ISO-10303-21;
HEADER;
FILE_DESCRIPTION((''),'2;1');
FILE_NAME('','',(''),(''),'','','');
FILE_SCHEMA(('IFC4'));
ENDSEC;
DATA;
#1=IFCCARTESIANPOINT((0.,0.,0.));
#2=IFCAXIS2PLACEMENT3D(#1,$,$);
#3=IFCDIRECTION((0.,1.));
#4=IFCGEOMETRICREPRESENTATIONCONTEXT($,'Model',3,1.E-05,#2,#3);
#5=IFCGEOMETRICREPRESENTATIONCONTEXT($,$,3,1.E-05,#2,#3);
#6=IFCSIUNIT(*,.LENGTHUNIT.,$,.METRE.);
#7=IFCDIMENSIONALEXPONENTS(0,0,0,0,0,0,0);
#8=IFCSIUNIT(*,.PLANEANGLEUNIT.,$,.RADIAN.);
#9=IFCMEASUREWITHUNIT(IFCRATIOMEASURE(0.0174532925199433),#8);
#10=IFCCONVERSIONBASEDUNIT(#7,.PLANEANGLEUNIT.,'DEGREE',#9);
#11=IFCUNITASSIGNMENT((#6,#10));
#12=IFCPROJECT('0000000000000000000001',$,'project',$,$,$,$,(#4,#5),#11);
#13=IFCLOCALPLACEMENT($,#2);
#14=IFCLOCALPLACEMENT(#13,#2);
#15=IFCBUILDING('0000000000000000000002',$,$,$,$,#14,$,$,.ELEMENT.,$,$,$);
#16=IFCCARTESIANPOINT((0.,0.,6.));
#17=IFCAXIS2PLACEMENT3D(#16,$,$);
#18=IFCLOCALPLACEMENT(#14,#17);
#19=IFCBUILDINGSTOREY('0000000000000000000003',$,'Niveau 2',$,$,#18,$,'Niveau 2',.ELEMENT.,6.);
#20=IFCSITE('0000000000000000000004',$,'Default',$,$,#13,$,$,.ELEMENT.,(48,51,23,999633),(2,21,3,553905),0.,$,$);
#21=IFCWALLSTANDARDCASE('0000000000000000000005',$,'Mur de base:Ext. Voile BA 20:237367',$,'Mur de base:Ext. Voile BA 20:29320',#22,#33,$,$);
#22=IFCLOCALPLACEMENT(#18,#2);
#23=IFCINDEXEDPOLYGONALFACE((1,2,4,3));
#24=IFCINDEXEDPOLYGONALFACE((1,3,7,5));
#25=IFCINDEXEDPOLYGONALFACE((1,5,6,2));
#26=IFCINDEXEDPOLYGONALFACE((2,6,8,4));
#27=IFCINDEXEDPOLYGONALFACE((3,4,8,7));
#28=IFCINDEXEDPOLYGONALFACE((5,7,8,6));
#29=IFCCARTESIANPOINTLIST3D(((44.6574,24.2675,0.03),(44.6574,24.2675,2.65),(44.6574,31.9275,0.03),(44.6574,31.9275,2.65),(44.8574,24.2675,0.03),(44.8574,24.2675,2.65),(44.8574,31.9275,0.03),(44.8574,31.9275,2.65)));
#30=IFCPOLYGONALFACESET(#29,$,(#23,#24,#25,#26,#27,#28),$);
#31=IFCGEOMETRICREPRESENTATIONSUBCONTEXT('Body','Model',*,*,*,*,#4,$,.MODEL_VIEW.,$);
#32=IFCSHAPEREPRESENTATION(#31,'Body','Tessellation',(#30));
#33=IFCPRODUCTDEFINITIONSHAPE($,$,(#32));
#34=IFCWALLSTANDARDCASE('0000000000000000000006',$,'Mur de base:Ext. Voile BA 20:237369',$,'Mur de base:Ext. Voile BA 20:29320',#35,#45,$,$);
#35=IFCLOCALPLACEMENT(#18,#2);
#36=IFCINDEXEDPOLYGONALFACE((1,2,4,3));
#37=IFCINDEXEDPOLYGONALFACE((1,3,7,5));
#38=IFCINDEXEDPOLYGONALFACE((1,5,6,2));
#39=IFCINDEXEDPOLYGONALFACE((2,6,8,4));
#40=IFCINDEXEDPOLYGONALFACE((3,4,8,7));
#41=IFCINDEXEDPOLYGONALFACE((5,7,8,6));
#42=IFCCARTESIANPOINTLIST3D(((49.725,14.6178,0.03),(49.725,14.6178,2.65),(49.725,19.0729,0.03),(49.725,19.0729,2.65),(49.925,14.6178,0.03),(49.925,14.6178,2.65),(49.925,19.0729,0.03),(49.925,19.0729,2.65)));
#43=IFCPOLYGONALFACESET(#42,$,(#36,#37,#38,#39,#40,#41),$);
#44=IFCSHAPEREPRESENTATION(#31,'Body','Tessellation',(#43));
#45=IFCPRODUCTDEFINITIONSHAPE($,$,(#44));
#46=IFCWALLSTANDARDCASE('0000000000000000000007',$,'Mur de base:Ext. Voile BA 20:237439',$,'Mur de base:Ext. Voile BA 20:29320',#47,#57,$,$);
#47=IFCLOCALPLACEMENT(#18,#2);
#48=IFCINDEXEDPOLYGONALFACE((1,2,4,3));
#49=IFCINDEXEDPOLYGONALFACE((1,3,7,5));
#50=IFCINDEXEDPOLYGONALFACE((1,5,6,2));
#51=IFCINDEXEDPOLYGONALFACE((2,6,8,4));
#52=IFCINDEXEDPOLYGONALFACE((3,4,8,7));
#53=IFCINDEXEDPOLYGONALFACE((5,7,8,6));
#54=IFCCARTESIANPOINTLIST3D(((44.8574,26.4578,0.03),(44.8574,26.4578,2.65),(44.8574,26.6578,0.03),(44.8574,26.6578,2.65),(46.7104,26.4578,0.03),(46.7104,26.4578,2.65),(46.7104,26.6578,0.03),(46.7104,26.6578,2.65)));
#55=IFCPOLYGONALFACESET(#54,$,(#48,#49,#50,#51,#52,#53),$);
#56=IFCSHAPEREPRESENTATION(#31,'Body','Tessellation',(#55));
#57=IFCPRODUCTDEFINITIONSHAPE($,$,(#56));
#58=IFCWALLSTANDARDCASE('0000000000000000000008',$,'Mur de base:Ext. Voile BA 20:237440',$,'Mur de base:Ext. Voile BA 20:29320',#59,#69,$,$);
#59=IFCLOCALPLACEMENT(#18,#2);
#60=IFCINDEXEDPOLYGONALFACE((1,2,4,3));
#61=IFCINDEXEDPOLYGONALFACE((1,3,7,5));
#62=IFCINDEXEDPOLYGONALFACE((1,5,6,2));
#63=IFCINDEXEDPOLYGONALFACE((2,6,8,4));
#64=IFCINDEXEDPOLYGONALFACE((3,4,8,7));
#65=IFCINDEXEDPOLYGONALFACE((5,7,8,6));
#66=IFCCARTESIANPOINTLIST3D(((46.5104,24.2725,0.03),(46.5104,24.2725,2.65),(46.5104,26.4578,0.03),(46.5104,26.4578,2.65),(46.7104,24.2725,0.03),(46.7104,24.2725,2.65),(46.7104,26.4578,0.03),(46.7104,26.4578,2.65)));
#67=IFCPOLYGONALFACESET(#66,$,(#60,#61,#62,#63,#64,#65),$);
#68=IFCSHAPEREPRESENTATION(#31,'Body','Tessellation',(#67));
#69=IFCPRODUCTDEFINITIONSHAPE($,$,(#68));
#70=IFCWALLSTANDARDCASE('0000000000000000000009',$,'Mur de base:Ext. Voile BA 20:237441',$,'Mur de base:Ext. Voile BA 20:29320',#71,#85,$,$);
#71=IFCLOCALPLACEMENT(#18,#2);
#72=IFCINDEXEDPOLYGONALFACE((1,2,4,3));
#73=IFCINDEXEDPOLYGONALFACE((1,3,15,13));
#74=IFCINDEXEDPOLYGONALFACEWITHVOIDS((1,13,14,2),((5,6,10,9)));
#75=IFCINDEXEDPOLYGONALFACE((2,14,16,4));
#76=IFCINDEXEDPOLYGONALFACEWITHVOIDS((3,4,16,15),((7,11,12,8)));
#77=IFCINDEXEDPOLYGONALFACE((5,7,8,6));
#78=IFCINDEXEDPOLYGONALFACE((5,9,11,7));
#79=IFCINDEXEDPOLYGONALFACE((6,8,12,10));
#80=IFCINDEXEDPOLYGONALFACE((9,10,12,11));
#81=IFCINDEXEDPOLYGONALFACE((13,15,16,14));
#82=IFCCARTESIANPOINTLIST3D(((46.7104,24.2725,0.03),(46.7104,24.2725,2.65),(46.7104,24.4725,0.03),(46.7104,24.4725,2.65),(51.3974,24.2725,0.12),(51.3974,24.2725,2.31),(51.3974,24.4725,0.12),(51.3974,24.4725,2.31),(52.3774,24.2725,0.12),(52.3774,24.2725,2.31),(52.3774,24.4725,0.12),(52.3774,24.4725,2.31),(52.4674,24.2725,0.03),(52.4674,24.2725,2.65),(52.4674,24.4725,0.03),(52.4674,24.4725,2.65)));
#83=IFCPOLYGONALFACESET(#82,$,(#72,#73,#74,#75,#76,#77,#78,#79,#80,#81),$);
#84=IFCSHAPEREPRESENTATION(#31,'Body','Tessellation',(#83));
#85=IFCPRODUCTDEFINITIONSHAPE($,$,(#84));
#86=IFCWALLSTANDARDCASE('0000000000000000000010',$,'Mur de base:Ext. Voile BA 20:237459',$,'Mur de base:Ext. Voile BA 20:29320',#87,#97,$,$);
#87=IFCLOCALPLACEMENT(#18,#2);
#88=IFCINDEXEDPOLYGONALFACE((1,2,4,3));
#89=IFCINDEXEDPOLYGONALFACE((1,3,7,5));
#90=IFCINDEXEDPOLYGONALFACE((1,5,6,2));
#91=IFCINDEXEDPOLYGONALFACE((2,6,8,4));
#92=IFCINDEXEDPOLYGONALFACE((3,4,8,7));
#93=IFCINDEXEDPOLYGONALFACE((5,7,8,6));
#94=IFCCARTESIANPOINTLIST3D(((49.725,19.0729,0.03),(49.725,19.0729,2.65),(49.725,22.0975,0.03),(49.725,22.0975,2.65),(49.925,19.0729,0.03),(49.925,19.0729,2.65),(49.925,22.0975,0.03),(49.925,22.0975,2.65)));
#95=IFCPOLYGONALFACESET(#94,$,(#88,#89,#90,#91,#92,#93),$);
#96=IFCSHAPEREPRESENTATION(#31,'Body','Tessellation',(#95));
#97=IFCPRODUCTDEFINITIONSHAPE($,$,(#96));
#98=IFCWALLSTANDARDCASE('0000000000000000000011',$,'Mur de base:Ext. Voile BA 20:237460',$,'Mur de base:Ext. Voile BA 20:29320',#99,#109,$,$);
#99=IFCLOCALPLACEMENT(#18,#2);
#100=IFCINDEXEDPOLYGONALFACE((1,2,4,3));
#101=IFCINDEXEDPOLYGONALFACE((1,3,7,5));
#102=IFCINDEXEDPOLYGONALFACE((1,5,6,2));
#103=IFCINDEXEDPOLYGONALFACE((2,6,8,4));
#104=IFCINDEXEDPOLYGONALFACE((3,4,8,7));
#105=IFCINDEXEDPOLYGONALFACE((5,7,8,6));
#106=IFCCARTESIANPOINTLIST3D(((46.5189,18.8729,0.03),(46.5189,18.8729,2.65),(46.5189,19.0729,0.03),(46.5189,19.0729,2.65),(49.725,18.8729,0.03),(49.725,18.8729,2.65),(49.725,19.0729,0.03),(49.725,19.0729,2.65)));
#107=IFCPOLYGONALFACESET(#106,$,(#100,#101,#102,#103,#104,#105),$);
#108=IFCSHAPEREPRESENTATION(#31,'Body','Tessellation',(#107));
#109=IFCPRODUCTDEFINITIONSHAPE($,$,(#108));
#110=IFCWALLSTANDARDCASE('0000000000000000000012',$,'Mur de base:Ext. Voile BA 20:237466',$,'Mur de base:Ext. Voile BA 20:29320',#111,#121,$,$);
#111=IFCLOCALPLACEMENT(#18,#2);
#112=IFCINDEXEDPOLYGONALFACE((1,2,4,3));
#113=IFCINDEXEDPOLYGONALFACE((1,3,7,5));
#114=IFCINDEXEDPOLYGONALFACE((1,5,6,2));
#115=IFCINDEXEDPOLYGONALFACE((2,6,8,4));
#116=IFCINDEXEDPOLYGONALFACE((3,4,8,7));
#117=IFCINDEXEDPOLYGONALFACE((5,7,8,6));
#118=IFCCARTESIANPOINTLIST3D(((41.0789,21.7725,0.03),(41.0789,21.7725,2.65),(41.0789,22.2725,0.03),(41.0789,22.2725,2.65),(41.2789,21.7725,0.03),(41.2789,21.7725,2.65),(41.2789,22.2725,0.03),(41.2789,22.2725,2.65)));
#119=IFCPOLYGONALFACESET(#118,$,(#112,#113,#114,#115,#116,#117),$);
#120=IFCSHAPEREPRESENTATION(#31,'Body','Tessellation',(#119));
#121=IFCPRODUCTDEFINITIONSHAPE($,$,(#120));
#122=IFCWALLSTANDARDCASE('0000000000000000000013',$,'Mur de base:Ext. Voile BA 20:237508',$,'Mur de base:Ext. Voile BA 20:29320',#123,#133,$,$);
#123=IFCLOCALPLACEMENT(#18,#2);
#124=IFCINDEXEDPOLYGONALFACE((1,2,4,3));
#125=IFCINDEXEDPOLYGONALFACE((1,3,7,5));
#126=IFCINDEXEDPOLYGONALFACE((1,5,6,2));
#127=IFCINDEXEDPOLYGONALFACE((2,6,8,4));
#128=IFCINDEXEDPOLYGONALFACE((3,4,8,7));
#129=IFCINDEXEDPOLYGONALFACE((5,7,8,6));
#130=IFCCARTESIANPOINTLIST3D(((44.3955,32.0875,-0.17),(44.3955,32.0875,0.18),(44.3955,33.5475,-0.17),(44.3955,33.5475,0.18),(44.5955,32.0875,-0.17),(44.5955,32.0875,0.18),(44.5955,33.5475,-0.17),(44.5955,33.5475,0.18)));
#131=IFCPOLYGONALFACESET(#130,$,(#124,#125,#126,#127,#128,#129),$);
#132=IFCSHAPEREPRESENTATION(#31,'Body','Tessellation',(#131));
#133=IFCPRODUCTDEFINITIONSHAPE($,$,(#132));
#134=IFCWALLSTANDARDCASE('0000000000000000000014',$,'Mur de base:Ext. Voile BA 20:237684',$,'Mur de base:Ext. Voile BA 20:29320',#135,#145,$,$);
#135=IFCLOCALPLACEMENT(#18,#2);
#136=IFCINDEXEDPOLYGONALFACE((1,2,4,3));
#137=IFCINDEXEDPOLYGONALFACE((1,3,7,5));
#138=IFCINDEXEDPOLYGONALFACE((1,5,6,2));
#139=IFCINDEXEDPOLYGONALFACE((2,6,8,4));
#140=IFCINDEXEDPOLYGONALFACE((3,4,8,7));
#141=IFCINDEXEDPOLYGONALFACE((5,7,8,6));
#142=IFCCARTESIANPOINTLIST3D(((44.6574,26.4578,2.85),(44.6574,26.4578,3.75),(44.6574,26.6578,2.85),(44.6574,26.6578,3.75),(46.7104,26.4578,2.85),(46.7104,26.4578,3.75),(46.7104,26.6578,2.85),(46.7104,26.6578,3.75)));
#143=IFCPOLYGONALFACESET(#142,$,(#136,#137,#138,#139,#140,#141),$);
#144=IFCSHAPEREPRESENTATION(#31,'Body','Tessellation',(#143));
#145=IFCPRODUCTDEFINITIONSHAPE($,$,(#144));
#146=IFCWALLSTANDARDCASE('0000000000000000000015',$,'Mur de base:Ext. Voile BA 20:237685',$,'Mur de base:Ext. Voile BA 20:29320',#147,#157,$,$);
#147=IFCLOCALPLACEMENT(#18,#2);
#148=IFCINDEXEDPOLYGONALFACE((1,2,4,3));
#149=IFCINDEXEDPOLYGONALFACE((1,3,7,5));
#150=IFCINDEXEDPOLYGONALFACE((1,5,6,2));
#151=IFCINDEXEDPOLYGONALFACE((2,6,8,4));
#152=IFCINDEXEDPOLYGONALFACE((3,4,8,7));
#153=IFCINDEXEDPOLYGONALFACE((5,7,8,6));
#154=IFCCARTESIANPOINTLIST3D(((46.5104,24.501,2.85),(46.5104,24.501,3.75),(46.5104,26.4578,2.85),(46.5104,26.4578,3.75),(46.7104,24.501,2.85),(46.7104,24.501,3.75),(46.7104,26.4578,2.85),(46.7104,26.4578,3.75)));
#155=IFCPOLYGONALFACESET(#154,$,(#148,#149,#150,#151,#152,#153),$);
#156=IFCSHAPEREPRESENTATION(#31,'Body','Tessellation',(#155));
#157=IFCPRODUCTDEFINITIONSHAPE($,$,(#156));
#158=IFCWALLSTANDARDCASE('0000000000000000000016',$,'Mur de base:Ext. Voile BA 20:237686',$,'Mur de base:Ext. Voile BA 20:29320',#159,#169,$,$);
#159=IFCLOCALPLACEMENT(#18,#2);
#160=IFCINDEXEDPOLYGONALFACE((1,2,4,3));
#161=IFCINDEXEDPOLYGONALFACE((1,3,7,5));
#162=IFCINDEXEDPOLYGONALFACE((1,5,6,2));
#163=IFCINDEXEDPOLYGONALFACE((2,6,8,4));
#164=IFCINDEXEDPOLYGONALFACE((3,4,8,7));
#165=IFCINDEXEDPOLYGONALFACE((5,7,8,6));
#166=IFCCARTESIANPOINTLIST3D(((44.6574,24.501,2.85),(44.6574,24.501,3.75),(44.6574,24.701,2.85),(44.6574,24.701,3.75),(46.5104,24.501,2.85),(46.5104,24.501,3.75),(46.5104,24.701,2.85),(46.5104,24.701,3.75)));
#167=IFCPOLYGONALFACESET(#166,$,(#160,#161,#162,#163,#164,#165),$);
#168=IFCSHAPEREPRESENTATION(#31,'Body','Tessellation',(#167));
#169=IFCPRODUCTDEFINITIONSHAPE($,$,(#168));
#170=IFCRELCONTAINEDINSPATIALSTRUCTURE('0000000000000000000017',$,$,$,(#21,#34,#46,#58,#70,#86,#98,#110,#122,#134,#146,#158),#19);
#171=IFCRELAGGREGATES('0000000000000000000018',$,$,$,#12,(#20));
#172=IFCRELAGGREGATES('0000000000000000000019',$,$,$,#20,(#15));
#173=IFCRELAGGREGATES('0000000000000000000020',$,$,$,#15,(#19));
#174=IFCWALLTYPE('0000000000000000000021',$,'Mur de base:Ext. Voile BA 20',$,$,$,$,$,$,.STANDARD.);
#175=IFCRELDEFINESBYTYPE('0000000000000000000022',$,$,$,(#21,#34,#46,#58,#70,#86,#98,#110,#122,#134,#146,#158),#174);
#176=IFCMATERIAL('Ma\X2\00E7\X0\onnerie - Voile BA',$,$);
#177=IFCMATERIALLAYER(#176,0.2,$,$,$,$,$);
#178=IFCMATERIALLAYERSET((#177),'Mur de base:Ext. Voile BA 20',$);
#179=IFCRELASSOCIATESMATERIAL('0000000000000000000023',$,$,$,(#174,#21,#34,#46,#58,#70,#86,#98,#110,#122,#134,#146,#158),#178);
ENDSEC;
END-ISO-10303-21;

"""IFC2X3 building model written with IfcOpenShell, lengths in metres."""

from ifc_helpers import new_model, entity, si_unit, converted_unit, direction, frame, frame_2d, origin, place, context, subcontext, project, spatial, rectangle, extrude, material, layer, layer_set, layer_usage, type_object, element, save


model = new_model("IFC2X3")

# Units and contexts
model_context = context("Model", 3, precision=1e-05, world=origin(), true_north=direction((0.0, 1.0)))
context_of_model = context(None, 3, precision=1e-05, world=origin(), true_north=direction((0.0, 1.0)))
body_context = subcontext(model_context, "Body", "Model", "MODEL_VIEW")
ifc_project = project(units=[si_unit("LENGTHUNIT", "METRE"), converted_unit("PLANEANGLEUNIT", "DEGREE", entity("IfcRatioMeasure", 0.0174532925199433), si_unit("PLANEANGLEUNIT", "RADIAN"), dimensions=[0, 0, 0, 0, 0, 0, 0])], contexts=[model_context, context_of_model])

# Site, building, storey
site_placement = place(None, origin())
site = spatial("IfcSite", under=ifc_project, at=site_placement, Name="Default", CompositionType="ELEMENT", RefLatitude=(48, 51, 23, 999633), RefLongitude=(2, 21, 3, 553905), RefElevation=0.0)
building_placement = place(site_placement, origin())
building = spatial("IfcBuilding", under=site, at=building_placement, CompositionType="ELEMENT")
storey_placement = place(building_placement, frame((0.0, 0.0, 6.0)))
storey = spatial("IfcBuildingStorey", under=building, at=storey_placement, Name="Niveau 2", LongName="Niveau 2", CompositionType="ELEMENT", Elevation=6.0)

# Walls
ifc_material = material(Name="Maçonnerie - Voile BA")
ifc_layer_1 = layer(ifc_material, 0.2)
ifc_layer_set_1 = layer_set([ifc_layer_1], Name="Mur de base:Ext. Voile BA 20")
ifc_layer_usage_1 = layer_usage(ifc_layer_set_1, "AXIS2", "NEGATIVE", 0.1)
wall_type_1 = type_object("IfcWallType", Name="Mur de base:Ext. Voile BA 20", PredefinedType="STANDARD", material=ifc_layer_set_1)
wall_1_placement = place(storey_placement, frame((44.7574, 31.9275, 0.03), z_axis=(0.0, 0.0, 1.0), x_axis=(0.0, -1.0, 0.0)))
element("IfcWallStandardCase", 1, at=wall_1_placement, inside=storey, type_object=wall_type_1, material=ifc_layer_usage_1, Name="Mur de base:Ext. Voile BA 20:237367", ObjectType="Mur de base:Ext. Voile BA 20:29320", context=body_context, shape_type="SweptSolid", body=[
    extrude(rectangle(XDim=7.66, YDim=0.2, at=frame_2d((3.83, 0.0), x_axis=(-1.0, 0.0))), origin(), (0.0, 0.0, 1.0), 2.62),
])
ifc_layer_usage_2 = layer_usage(ifc_layer_set_1, "AXIS2", "NEGATIVE", 0.1)
wall_2_placement = place(storey_placement, frame((49.825, 19.0729, 0.03), z_axis=(0.0, 0.0, 1.0), x_axis=(0.0, -1.0, 0.0)))
element("IfcWallStandardCase", 2, at=wall_2_placement, inside=storey, type_object=wall_type_1, material=ifc_layer_usage_2, Name="Mur de base:Ext. Voile BA 20:237369", ObjectType="Mur de base:Ext. Voile BA 20:29320", context=body_context, shape_type="SweptSolid", body=[
    extrude(rectangle(XDim=4.4551, YDim=0.2, at=frame_2d((2.2275, 0.0), x_axis=(-1.0, 0.0))), origin(), (0.0, 0.0, 1.0), 2.62),
])
ifc_layer_usage_3 = layer_usage(ifc_layer_set_1, "AXIS2", "POSITIVE", -0.1)
wall_3_placement = place(storey_placement, frame((44.8574, 26.5578, 0.03)))
element("IfcWallStandardCase", 3, at=wall_3_placement, inside=storey, type_object=wall_type_1, material=ifc_layer_usage_3, Name="Mur de base:Ext. Voile BA 20:237439", ObjectType="Mur de base:Ext. Voile BA 20:29320", context=body_context, shape_type="SweptSolid", body=[
    extrude(rectangle(XDim=1.853, YDim=0.2, at=frame_2d((0.9265, 0.0), x_axis=(-1.0, 0.0))), origin(), (0.0, 0.0, 1.0), 2.62),
])
ifc_layer_usage_4 = layer_usage(ifc_layer_set_1, "AXIS2", "POSITIVE", -0.1)
wall_4_placement = place(storey_placement, frame((46.6104, 26.4578, 0.03), z_axis=(0.0, 0.0, 1.0), x_axis=(0.0, -1.0, 0.0)))
element("IfcWallStandardCase", 4, at=wall_4_placement, inside=storey, type_object=wall_type_1, material=ifc_layer_usage_4, Name="Mur de base:Ext. Voile BA 20:237440", ObjectType="Mur de base:Ext. Voile BA 20:29320", context=body_context, shape_type="SweptSolid", body=[
    extrude(rectangle(XDim=2.1853, YDim=0.2, at=frame_2d((1.0926, 0.0), x_axis=(-1.0, 0.0))), origin(), (0.0, 0.0, 1.0), 2.62),
])

# Wall, opening
ifc_layer_usage_5 = layer_usage(ifc_layer_set_1, "AXIS2", "POSITIVE", -0.1)
wall_5_placement = place(storey_placement, frame((46.7104, 24.3725, 0.03)))
wall_5 = element("IfcWallStandardCase", 5, at=wall_5_placement, inside=storey, type_object=wall_type_1, material=ifc_layer_usage_5, Name="Mur de base:Ext. Voile BA 20:237441", ObjectType="Mur de base:Ext. Voile BA 20:29320", context=body_context, shape_type="SweptSolid", body=[
    extrude(rectangle(XDim=5.757, YDim=0.2, at=frame_2d((2.8785, 0.0), x_axis=(-1.0, 0.0))), origin(), (0.0, 0.0, 1.0), 2.62),
])
opening_1_placement = place(wall_5_placement, origin())
element("IfcOpeningElement", 6, at=opening_1_placement, cuts=wall_5, ObjectType="Opening", context=body_context, shape_type="SweptSolid", body=[
    extrude(rectangle(XDim=2.19, YDim=0.98, at=frame_2d((0.0, 0.0), x_axis=(1.0, 0.0))), frame((5.177, -0.1, 1.185), z_axis=(0.0, 1.0, 0.0), x_axis=(0.0, 0.0, -1.0)), (0.0, 0.0, 1.0), 0.2),
])

# Walls
ifc_layer_usage_6 = layer_usage(ifc_layer_set_1, "AXIS2", "NEGATIVE", 0.1)
wall_6_placement = place(storey_placement, frame((49.825, 19.0729, 0.03), z_axis=(0.0, 0.0, 1.0), x_axis=(0.0, 1.0, 0.0)))
element("IfcWallStandardCase", 7, at=wall_6_placement, inside=storey, type_object=wall_type_1, material=ifc_layer_usage_6, Name="Mur de base:Ext. Voile BA 20:237459", ObjectType="Mur de base:Ext. Voile BA 20:29320", context=body_context, shape_type="SweptSolid", body=[
    extrude(rectangle(XDim=3.0246, YDim=0.2, at=frame_2d((1.5123, 0.0), x_axis=(-1.0, 0.0))), origin(), (0.0, 0.0, 1.0), 2.62),
])
ifc_layer_usage_7 = layer_usage(ifc_layer_set_1, "AXIS2", "POSITIVE", -0.1)
wall_7_placement = place(storey_placement, frame((49.725, 18.9729, 0.03), z_axis=(0.0, 0.0, 1.0), x_axis=(-1.0, 0.0, 0.0)))
element("IfcWallStandardCase", 8, at=wall_7_placement, inside=storey, type_object=wall_type_1, material=ifc_layer_usage_7, Name="Mur de base:Ext. Voile BA 20:237460", ObjectType="Mur de base:Ext. Voile BA 20:29320", context=body_context, shape_type="SweptSolid", body=[
    extrude(rectangle(XDim=3.2061, YDim=0.2, at=frame_2d((1.6031, 0.0), x_axis=(-1.0, 0.0))), origin(), (0.0, 0.0, 1.0), 2.62),
])
ifc_layer_usage_8 = layer_usage(ifc_layer_set_1, "AXIS2", "POSITIVE", -0.1)
wall_8_placement = place(storey_placement, frame((41.1789, 21.7725, 0.03), z_axis=(0.0, 0.0, 1.0), x_axis=(0.0, 1.0, 0.0)))
element("IfcWallStandardCase", 9, at=wall_8_placement, inside=storey, type_object=wall_type_1, material=ifc_layer_usage_8, Name="Mur de base:Ext. Voile BA 20:237466", ObjectType="Mur de base:Ext. Voile BA 20:29320", context=body_context, shape_type="SweptSolid", body=[
    extrude(rectangle(XDim=0.5, YDim=0.2, at=frame_2d((0.25, 0.0), x_axis=(-1.0, 0.0))), origin(), (0.0, 0.0, 1.0), 2.62),
])
ifc_layer_usage_9 = layer_usage(ifc_layer_set_1, "AXIS2", "NEGATIVE", 0.1)
wall_9_placement = place(storey_placement, frame((44.4955, 33.5475, -0.17), z_axis=(0.0, 0.0, 1.0), x_axis=(0.0, -1.0, 0.0)))
element("IfcWallStandardCase", 10, at=wall_9_placement, inside=storey, type_object=wall_type_1, material=ifc_layer_usage_9, Name="Mur de base:Ext. Voile BA 20:237508", ObjectType="Mur de base:Ext. Voile BA 20:29320", context=body_context, shape_type="SweptSolid", body=[
    extrude(rectangle(XDim=1.46, YDim=0.2, at=frame_2d((0.73, 0.0), x_axis=(-1.0, 0.0))), origin(), (0.0, 0.0, 1.0), 0.35),
])

# Walls
ifc_layer_usage_10 = layer_usage(ifc_layer_set_1, "AXIS2", "NEGATIVE", 0.1)
wall_10_placement = place(storey_placement, frame((44.6574, 26.5578, 2.85)))
element("IfcWallStandardCase", 11, at=wall_10_placement, inside=storey, type_object=wall_type_1, material=ifc_layer_usage_10, Name="Mur de base:Ext. Voile BA 20:237684", ObjectType="Mur de base:Ext. Voile BA 20:29320", context=body_context, shape_type="SweptSolid", body=[
    extrude(rectangle(XDim=2.053, YDim=0.2, at=frame_2d((1.0265, 0.0), x_axis=(-1.0, 0.0))), origin(), (0.0, 0.0, 1.0), 0.9),
])
ifc_layer_usage_11 = layer_usage(ifc_layer_set_1, "AXIS2", "NEGATIVE", 0.1)
wall_11_placement = place(storey_placement, frame((46.6104, 26.4578, 2.85), z_axis=(0.0, 0.0, 1.0), x_axis=(0.0, -1.0, 0.0)))
element("IfcWallStandardCase", 12, at=wall_11_placement, inside=storey, type_object=wall_type_1, material=ifc_layer_usage_11, Name="Mur de base:Ext. Voile BA 20:237685", ObjectType="Mur de base:Ext. Voile BA 20:29320", context=body_context, shape_type="SweptSolid", body=[
    extrude(rectangle(XDim=1.9568, YDim=0.2, at=frame_2d((0.9784, 0.0), x_axis=(-1.0, 0.0))), origin(), (0.0, 0.0, 1.0), 0.9),
])
ifc_layer_usage_12 = layer_usage(ifc_layer_set_1, "AXIS2", "NEGATIVE", 0.1)
wall_12_placement = place(storey_placement, frame((46.5104, 24.601, 2.85), z_axis=(0.0, 0.0, 1.0), x_axis=(-1.0, 0.0, 0.0)))
element("IfcWallStandardCase", 13, at=wall_12_placement, inside=storey, type_object=wall_type_1, material=ifc_layer_usage_12, Name="Mur de base:Ext. Voile BA 20:237686", ObjectType="Mur de base:Ext. Voile BA 20:29320", context=body_context, shape_type="SweptSolid", body=[
    extrude(rectangle(XDim=1.853, YDim=0.2, at=frame_2d((0.9265, 0.0), x_axis=(-1.0, 0.0))), origin(), (0.0, 0.0, 1.0), 0.9),
])

save(model, "model.ifc")
